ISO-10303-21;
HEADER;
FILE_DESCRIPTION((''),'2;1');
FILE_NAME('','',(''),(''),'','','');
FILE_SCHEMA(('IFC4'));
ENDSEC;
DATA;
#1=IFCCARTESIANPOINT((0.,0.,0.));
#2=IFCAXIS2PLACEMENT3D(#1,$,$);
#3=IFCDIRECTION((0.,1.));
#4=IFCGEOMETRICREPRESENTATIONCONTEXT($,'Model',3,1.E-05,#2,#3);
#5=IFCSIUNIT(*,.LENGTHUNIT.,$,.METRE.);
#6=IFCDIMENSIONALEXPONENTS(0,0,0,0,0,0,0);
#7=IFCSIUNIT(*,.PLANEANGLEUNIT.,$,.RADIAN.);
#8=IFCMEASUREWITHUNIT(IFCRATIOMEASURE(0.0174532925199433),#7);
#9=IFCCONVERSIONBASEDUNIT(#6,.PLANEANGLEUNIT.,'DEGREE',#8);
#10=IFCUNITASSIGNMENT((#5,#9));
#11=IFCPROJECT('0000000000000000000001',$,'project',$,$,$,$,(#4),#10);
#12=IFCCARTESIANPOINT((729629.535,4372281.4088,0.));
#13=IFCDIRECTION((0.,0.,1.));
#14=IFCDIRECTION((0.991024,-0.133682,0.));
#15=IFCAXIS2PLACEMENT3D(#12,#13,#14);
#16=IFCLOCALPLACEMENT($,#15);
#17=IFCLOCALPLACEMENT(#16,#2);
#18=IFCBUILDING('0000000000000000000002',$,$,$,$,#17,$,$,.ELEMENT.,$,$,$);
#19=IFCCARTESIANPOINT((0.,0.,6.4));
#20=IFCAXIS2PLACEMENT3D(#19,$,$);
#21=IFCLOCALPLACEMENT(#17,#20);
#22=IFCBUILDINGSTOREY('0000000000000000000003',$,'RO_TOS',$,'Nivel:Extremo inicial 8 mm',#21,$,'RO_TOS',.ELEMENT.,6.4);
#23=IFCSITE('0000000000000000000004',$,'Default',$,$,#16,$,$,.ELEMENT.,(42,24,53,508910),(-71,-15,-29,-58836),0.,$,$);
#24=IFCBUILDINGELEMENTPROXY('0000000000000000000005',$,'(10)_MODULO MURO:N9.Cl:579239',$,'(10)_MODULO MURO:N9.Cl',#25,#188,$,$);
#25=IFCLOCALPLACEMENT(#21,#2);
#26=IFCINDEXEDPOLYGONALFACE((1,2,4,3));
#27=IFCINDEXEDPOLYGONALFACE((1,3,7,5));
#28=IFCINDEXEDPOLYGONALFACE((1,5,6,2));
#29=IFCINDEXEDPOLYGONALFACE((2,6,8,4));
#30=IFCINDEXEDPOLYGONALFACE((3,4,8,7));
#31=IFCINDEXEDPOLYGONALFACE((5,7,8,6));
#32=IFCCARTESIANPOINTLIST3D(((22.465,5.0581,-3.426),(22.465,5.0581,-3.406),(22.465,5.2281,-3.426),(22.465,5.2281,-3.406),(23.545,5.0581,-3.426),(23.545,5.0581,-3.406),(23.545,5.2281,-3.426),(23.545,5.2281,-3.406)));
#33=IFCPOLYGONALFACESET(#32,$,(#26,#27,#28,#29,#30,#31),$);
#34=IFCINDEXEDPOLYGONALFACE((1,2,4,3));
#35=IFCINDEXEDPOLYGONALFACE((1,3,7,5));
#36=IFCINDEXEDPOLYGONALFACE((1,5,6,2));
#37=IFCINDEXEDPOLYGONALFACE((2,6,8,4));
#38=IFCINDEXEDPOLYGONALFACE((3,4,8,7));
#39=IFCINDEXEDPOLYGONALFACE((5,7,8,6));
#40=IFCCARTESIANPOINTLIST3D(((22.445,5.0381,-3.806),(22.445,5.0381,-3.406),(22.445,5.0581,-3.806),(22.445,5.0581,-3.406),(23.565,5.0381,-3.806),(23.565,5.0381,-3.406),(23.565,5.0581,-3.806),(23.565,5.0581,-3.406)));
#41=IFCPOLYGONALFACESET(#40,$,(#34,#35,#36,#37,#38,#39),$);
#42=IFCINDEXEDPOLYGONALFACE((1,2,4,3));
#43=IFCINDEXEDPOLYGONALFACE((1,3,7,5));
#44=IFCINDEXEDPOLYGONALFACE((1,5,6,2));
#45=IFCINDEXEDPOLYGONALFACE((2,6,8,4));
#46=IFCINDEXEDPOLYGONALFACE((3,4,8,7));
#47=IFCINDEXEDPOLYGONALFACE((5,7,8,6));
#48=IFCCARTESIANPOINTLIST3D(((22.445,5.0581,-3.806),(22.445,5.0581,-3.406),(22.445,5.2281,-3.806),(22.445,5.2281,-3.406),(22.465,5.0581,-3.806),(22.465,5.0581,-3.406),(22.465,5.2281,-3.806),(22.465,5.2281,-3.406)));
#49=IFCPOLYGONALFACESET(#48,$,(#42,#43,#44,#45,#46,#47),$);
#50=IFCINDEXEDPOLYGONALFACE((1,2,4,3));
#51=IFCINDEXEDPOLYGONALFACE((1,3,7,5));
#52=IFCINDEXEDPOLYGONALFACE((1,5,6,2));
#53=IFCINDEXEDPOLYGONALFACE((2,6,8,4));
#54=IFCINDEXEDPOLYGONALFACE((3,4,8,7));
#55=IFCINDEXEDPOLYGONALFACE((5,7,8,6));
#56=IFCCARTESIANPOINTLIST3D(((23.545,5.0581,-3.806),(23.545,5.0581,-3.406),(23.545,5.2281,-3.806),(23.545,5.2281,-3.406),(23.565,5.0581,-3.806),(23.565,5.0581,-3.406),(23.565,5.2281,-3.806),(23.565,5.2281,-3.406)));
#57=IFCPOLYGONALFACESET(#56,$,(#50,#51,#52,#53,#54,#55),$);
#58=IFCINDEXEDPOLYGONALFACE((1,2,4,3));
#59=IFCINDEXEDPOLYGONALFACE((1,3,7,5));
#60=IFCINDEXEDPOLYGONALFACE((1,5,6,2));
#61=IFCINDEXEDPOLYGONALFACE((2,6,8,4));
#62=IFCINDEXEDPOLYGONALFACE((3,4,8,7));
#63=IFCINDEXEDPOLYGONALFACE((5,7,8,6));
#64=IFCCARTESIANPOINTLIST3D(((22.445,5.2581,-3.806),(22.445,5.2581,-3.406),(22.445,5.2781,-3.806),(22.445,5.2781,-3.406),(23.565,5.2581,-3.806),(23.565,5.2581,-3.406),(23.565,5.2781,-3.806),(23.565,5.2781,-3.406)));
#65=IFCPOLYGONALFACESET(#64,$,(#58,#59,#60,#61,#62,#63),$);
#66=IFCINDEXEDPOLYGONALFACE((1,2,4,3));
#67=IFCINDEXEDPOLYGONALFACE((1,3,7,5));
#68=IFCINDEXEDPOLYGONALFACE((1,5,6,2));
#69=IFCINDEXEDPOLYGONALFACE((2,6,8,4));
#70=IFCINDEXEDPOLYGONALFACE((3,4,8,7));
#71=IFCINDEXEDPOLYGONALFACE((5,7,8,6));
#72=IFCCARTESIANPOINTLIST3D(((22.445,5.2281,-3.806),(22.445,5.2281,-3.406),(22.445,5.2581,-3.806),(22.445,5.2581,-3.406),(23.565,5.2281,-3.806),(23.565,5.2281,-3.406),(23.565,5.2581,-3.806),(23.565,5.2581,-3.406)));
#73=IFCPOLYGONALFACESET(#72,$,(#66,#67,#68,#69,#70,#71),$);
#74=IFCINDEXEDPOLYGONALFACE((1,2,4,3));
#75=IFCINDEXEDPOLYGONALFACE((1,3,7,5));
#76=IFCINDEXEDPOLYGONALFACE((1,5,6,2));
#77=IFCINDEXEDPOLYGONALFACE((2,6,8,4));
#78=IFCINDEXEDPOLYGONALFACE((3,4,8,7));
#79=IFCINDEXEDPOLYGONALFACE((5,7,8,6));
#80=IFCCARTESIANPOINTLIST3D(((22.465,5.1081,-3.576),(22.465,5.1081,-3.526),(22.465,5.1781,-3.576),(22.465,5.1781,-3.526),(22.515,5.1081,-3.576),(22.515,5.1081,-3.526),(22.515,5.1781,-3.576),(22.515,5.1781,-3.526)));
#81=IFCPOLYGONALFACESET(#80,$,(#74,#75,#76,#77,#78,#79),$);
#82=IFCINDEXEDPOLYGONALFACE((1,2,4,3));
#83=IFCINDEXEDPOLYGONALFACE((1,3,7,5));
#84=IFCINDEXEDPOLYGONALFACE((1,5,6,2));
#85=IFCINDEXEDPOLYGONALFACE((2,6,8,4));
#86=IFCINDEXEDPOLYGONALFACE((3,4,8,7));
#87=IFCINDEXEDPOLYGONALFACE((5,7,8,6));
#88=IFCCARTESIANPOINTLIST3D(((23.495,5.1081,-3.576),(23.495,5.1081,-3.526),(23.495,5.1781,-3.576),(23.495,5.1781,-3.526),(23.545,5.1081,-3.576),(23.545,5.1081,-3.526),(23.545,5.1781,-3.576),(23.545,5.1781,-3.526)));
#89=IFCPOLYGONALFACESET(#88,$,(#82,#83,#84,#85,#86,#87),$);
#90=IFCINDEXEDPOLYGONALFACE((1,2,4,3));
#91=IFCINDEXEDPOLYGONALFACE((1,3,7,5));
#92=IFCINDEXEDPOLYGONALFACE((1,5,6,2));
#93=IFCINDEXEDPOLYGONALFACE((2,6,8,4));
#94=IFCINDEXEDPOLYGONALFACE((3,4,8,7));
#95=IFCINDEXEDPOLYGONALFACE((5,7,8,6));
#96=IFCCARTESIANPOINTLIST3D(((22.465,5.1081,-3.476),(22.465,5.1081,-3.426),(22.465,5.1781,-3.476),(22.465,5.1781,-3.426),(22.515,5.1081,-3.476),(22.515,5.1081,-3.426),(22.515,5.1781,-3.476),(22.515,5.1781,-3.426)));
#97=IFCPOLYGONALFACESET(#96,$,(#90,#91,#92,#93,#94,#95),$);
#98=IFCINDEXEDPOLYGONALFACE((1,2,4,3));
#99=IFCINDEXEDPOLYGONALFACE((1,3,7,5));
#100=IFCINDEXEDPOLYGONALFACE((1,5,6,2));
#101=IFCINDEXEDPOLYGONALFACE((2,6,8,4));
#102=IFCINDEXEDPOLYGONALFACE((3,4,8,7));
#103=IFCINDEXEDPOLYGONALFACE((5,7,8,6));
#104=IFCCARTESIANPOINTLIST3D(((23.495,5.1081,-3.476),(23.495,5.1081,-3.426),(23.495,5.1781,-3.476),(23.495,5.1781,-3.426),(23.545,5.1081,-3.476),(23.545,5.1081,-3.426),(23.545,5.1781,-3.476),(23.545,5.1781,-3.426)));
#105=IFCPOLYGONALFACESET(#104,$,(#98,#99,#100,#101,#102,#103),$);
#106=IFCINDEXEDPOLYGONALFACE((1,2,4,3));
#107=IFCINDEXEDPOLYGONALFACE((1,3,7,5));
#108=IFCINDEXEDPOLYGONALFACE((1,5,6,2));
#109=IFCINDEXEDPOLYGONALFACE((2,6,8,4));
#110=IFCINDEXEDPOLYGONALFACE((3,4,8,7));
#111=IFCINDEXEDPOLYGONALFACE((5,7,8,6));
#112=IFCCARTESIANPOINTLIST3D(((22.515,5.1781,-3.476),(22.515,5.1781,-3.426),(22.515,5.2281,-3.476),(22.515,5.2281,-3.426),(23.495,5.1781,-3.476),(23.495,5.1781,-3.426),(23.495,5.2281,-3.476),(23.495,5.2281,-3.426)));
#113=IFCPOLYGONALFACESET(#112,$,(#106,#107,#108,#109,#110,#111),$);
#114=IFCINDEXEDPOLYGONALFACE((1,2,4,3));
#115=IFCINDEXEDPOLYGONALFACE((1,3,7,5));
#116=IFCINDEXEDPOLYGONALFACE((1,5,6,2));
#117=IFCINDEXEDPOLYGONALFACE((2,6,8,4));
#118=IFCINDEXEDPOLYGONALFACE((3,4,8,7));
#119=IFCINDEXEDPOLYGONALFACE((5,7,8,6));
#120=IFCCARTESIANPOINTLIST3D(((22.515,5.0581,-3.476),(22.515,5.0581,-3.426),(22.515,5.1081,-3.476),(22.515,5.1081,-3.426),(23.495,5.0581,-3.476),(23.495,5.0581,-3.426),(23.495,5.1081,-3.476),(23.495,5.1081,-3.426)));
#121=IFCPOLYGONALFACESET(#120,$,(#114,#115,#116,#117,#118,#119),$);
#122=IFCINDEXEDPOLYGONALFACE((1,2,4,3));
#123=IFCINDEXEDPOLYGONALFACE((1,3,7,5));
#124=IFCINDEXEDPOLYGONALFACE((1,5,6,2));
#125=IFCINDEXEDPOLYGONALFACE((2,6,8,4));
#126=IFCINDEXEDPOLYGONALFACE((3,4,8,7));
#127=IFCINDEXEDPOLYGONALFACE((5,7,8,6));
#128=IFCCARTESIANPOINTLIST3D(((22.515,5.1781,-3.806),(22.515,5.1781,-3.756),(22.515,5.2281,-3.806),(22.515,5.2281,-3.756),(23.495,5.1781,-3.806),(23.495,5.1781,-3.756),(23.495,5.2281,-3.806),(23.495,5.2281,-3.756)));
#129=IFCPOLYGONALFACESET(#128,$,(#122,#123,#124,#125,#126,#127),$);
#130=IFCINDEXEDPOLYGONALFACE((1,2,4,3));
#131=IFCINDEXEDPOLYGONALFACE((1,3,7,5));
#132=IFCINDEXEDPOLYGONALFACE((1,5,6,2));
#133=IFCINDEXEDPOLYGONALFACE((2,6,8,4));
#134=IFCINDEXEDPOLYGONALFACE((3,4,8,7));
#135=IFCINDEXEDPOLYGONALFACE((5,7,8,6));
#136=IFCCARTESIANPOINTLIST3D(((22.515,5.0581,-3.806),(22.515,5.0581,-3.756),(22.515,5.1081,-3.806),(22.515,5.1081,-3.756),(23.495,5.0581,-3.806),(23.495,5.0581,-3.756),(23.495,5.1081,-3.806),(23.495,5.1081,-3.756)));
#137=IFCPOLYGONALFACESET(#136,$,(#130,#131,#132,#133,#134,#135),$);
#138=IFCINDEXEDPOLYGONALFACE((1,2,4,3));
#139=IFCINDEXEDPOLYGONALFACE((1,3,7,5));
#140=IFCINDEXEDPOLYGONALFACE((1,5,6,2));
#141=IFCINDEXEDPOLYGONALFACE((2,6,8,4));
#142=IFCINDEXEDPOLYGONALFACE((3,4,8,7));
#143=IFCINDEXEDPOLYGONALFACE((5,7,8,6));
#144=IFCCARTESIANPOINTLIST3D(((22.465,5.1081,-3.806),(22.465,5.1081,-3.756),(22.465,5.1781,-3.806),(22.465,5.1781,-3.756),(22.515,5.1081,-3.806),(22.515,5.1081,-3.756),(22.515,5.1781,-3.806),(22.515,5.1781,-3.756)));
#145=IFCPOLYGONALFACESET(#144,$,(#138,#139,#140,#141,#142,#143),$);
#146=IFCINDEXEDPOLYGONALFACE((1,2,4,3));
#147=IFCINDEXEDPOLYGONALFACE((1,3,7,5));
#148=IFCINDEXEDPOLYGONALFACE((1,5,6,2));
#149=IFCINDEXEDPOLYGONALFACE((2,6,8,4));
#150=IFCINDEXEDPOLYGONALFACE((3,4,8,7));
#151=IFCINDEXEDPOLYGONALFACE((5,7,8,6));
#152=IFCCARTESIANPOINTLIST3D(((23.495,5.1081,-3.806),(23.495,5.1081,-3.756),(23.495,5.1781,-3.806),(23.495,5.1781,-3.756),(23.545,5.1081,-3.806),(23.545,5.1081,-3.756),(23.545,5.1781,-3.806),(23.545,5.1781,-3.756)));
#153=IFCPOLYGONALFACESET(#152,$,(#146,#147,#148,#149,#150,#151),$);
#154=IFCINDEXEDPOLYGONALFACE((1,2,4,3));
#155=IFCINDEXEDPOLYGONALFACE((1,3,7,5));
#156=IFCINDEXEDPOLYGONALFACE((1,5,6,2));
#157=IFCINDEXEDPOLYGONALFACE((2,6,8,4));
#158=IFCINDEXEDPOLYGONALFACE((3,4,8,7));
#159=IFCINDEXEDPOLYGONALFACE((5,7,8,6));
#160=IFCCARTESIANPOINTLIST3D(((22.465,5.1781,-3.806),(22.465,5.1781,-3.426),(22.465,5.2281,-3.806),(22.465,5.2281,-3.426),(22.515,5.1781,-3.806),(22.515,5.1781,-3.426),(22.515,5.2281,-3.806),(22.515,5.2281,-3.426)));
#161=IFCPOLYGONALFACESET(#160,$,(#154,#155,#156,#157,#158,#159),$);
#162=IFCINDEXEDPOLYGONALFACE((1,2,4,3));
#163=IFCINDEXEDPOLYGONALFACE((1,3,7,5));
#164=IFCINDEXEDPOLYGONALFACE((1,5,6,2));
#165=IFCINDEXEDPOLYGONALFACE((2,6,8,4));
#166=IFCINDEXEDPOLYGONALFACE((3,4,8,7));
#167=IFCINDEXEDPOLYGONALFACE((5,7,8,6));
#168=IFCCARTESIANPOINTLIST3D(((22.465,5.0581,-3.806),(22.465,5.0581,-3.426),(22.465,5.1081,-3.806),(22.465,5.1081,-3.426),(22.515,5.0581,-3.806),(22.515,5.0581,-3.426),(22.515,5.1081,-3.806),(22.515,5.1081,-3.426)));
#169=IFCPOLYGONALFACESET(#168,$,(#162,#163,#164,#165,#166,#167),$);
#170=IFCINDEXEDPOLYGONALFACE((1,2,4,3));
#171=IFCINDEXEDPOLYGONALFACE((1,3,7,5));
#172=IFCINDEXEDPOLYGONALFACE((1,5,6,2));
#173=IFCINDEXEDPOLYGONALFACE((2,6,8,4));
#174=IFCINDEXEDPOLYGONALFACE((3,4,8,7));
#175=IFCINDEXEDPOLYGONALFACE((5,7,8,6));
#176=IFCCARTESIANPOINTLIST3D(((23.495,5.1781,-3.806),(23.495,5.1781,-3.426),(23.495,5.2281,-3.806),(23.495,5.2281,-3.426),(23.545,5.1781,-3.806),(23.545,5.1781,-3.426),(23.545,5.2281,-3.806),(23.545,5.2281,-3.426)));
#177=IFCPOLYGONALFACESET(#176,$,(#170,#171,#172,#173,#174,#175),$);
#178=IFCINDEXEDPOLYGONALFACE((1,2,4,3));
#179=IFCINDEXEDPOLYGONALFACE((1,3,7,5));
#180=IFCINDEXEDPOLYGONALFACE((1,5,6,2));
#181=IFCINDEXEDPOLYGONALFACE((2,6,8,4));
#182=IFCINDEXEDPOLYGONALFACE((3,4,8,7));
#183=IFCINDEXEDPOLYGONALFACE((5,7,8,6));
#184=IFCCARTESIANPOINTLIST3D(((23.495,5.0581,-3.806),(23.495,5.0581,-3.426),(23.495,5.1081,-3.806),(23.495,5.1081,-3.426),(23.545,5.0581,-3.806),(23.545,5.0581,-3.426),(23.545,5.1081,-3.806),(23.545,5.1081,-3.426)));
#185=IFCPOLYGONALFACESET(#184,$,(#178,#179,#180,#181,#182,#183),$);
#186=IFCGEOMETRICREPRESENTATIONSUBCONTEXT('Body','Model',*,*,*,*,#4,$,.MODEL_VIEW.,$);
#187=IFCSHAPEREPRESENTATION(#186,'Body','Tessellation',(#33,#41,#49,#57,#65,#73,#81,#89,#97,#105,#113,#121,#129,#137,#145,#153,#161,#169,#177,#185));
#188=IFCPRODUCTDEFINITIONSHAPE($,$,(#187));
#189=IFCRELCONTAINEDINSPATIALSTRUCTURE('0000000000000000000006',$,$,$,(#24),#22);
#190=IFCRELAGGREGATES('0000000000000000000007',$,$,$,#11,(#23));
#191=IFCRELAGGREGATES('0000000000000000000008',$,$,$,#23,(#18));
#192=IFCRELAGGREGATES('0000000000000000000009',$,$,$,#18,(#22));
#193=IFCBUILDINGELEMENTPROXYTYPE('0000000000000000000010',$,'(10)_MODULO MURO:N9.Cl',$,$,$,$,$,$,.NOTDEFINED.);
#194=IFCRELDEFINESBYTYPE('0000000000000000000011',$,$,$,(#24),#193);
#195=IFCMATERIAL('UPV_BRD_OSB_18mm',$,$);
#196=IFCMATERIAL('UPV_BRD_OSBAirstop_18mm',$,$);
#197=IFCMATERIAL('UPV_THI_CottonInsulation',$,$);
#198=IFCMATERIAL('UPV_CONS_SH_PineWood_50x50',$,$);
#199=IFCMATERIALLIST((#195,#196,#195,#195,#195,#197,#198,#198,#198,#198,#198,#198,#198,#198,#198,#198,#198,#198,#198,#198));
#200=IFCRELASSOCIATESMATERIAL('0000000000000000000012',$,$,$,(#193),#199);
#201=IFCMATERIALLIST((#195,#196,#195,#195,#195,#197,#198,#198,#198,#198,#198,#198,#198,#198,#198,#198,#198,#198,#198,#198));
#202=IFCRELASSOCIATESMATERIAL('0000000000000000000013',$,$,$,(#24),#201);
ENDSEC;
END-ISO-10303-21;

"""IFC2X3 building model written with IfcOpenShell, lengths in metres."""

from ifc_helpers import new_model, entity, si_unit, converted_unit, direction, frame, frame_2d, origin, origin_2d_with_axis, place, context, subcontext, project, spatial, rectangle, extrude, source, transform, mapped, material, material_list, type_object, type_shapes, element, save


model = new_model("IFC2X3")

# Units and contexts
model_context = context("Model", 3, precision=1e-05, world=origin(), true_north=direction((0.0, 1.0)))
body_context = subcontext(model_context, "Body", "Model", "MODEL_VIEW")
ifc_project = project(units=[si_unit("LENGTHUNIT", "METRE"), converted_unit("PLANEANGLEUNIT", "DEGREE", entity("IfcRatioMeasure", 0.0174532925199433), si_unit("PLANEANGLEUNIT", "RADIAN"), dimensions=[0, 0, 0, 0, 0, 0, 0])], contexts=[model_context])

# Site, building, storey
site_placement = place(None, frame((729629.535, 4372281.4088, 0.0), z_axis=(0.0, 0.0, 1.0), x_axis=(0.991024, -0.133682, 0.0)))
site = spatial("IfcSite", under=ifc_project, at=site_placement, Name="Default", CompositionType="ELEMENT", RefLatitude=(42, 24, 53, 508910), RefLongitude=(-71, -15, -29, -58836), RefElevation=0.0)
building_placement = place(site_placement, origin())
building = spatial("IfcBuilding", under=site, at=building_placement, CompositionType="ELEMENT")
storey_placement = place(building_placement, frame((0.0, 0.0, 6.4)))
storey = spatial("IfcBuildingStorey", under=building, at=storey_placement, Name="RO_TOS", ObjectType="Nivel:Extremo inicial 8 mm", LongName="RO_TOS", CompositionType="ELEMENT", Elevation=6.4)

# Building element proxy
ifc_material_1 = material(Name="UPV_BRD_OSB_18mm")
ifc_material_2 = material(Name="UPV_BRD_OSBAirstop_18mm")
ifc_material_3 = material(Name="UPV_THI_CottonInsulation")
ifc_material_4 = material(Name="UPV_CONS_SH_PineWood_50x50")
ifc_material_list_1 = material_list([ifc_material_1, ifc_material_2, ifc_material_1, ifc_material_1, ifc_material_1, ifc_material_3, ifc_material_4, ifc_material_4, ifc_material_4, ifc_material_4, ifc_material_4, ifc_material_4, ifc_material_4, ifc_material_4, ifc_material_4, ifc_material_4, ifc_material_4, ifc_material_4, ifc_material_4, ifc_material_4])
ifc_material_list_2 = material_list([ifc_material_1, ifc_material_2, ifc_material_1, ifc_material_1, ifc_material_1, ifc_material_3, ifc_material_4, ifc_material_4, ifc_material_4, ifc_material_4, ifc_material_4, ifc_material_4, ifc_material_4, ifc_material_4, ifc_material_4, ifc_material_4, ifc_material_4, ifc_material_4, ifc_material_4, ifc_material_4])
building_element_proxy_type_1 = type_object("IfcBuildingElementProxyType", Name="(10)_MODULO MURO:N9.Cl", PredefinedType="NOTDEFINED", material=ifc_material_list_2)
shared_shape_1 = source(origin(), body_context, "Body", "SweptSolid", [
    extrude(rectangle(XDim=1.08, YDim=0.17, at=origin_2d_with_axis()), frame((0.0, 0.0, 0.38), z_axis=(0.0, 0.0, 1.0), x_axis=(-1.0, 0.0, 0.0)), (0.0, 0.0, 1.0), 0.02),
    extrude(rectangle(XDim=1.12, YDim=0.02, at=origin_2d_with_axis()), frame((0.0, -0.095, 0.0)), (0.0, 0.0, 1.0), 0.4),
    extrude(rectangle(XDim=0.17, YDim=0.02, at=frame_2d((0.0, 0.0), x_axis=(1.0, 0.0))), frame((-0.55, 0.0, 0.0), z_axis=(0.0, 0.0, 1.0), x_axis=(0.0, -1.0, 0.0)), (0.0, 0.0, 1.0), 0.4),
    extrude(rectangle(XDim=0.17, YDim=0.02, at=frame_2d((0.0, 0.0), x_axis=(1.0, 0.0))), frame((0.55, 0.0, 0.0), z_axis=(0.0, 0.0, 1.0), x_axis=(0.0, -1.0, 0.0)), (0.0, 0.0, 1.0), 0.4),
    extrude(rectangle(XDim=1.12, YDim=0.02, at=origin_2d_with_axis()), frame((0.0, 0.125, 0.0), z_axis=(0.0, 0.0, 1.0), x_axis=(-1.0, 0.0, 0.0)), (0.0, 0.0, 1.0), 0.4),
    extrude(rectangle(XDim=1.12, YDim=0.03, at=frame_2d((0.0, 0.0), x_axis=(1.0, 0.0))), frame((0.0, 0.1, 0.0), z_axis=(0.0, 0.0, 1.0), x_axis=(-1.0, 0.0, 0.0)), (0.0, 0.0, 1.0), 0.4),
    extrude(rectangle(XDim=0.07, YDim=0.05, at=origin_2d_with_axis()), frame((-0.515, 0.0, 0.23), z_axis=(0.0, 0.0, 1.0), x_axis=(0.0, 1.0, 0.0)), (0.0, 0.0, 1.0), 0.05),
    extrude(rectangle(XDim=0.07, YDim=0.05, at=origin_2d_with_axis()), frame((0.515, 0.0, 0.23), z_axis=(0.0, 0.0, 1.0), x_axis=(0.0, 1.0, 0.0)), (0.0, 0.0, 1.0), 0.05),
    extrude(rectangle(XDim=0.07, YDim=0.05, at=frame_2d((0.0, 0.0), x_axis=(1.0, 0.0))), frame((-0.515, 0.0, 0.33), z_axis=(0.0, 0.0, 1.0), x_axis=(0.0, -1.0, 0.0)), (0.0, 0.0, 1.0), 0.05),
    extrude(rectangle(XDim=0.07, YDim=0.05, at=origin_2d_with_axis()), frame((0.515, 0.0, 0.33), z_axis=(0.0, 0.0, 1.0), x_axis=(0.0, -1.0, 0.0)), (0.0, 0.0, 1.0), 0.05),
    extrude(rectangle(XDim=0.98, YDim=0.05, at=origin_2d_with_axis()), frame((0.0, 0.06, 0.33), z_axis=(0.0, 0.0, 1.0), x_axis=(-1.0, 0.0, 0.0)), (0.0, 0.0, 1.0), 0.05),
    extrude(rectangle(XDim=0.05, YDim=0.98, at=frame_2d((0.0, 0.0), x_axis=(1.0, 0.0))), frame((0.0, -0.06, 0.33), z_axis=(0.0, 0.0, 1.0), x_axis=(0.0, -1.0, 0.0)), (0.0, 0.0, 1.0), 0.05),
    extrude(rectangle(XDim=0.05, YDim=0.98, at=origin_2d_with_axis()), frame((0.0, 0.06, 0.0), z_axis=(0.0, 0.0, 1.0), x_axis=(0.0, -1.0, 0.0)), (0.0, 0.0, 1.0), 0.05),
    extrude(rectangle(XDim=0.05, YDim=0.98, at=frame_2d((0.0, 0.0), x_axis=(1.0, 0.0))), frame((0.0, -0.06, 0.0), z_axis=(0.0, 0.0, 1.0), x_axis=(0.0, -1.0, 0.0)), (0.0, 0.0, 1.0), 0.05),
    extrude(rectangle(XDim=0.07, YDim=0.05, at=frame_2d((0.0, 0.0), x_axis=(1.0, 0.0))), frame((-0.515, 0.0, 0.0), z_axis=(0.0, 0.0, 1.0), x_axis=(0.0, -1.0, 0.0)), (0.0, 0.0, 1.0), 0.05),
    extrude(rectangle(XDim=0.05, YDim=0.07, at=origin_2d_with_axis()), frame((0.515, 0.0, 0.0), z_axis=(0.0, 0.0, 1.0), x_axis=(-1.0, 0.0, 0.0)), (0.0, 0.0, 1.0), 0.05),
    extrude(rectangle(XDim=0.05, YDim=0.05, at=frame_2d((0.0, 0.0), x_axis=(1.0, 0.0))), frame((-0.515, 0.06, 0.0), z_axis=(0.0, 0.0, 1.0), x_axis=(0.0, -1.0, 0.0)), (0.0, 0.0, 1.0), 0.38),
    extrude(rectangle(XDim=0.05, YDim=0.05, at=frame_2d((0.0, 0.0), x_axis=(1.0, 0.0))), frame((-0.515, -0.06, 0.0), z_axis=(0.0, 0.0, 1.0), x_axis=(0.0, -1.0, 0.0)), (0.0, 0.0, 1.0), 0.38),
    extrude(rectangle(XDim=0.05, YDim=0.05, at=origin_2d_with_axis()), frame((0.515, 0.06, 0.0), z_axis=(0.0, 0.0, 1.0), x_axis=(0.0, -1.0, 0.0)), (0.0, 0.0, 1.0), 0.38),
    extrude(rectangle(XDim=0.05, YDim=0.05, at=frame_2d((0.0, 0.0), x_axis=(1.0, 0.0))), frame((0.515, -0.06, 0.0), z_axis=(0.0, 0.0, 1.0), x_axis=(0.0, -1.0, 0.0)), (0.0, 0.0, 1.0), 0.38),
])
type_shapes(building_element_proxy_type_1, [shared_shape_1])
proxy_1_placement = place(storey_placement, frame((23.005, 5.1431, -3.806)))
element("IfcBuildingElementProxy", 1, at=proxy_1_placement, inside=storey, type_object=building_element_proxy_type_1, material=ifc_material_list_1, Name="(10)_MODULO MURO:N9.Cl:579239", ObjectType="(10)_MODULO MURO:N9.Cl", context=body_context, shape_type="MappedRepresentation", body=[
    mapped(shared_shape_1, transform((0.0, 0.0, 0.0), scale=1.0)),
])

save(model, "model.ifc")
